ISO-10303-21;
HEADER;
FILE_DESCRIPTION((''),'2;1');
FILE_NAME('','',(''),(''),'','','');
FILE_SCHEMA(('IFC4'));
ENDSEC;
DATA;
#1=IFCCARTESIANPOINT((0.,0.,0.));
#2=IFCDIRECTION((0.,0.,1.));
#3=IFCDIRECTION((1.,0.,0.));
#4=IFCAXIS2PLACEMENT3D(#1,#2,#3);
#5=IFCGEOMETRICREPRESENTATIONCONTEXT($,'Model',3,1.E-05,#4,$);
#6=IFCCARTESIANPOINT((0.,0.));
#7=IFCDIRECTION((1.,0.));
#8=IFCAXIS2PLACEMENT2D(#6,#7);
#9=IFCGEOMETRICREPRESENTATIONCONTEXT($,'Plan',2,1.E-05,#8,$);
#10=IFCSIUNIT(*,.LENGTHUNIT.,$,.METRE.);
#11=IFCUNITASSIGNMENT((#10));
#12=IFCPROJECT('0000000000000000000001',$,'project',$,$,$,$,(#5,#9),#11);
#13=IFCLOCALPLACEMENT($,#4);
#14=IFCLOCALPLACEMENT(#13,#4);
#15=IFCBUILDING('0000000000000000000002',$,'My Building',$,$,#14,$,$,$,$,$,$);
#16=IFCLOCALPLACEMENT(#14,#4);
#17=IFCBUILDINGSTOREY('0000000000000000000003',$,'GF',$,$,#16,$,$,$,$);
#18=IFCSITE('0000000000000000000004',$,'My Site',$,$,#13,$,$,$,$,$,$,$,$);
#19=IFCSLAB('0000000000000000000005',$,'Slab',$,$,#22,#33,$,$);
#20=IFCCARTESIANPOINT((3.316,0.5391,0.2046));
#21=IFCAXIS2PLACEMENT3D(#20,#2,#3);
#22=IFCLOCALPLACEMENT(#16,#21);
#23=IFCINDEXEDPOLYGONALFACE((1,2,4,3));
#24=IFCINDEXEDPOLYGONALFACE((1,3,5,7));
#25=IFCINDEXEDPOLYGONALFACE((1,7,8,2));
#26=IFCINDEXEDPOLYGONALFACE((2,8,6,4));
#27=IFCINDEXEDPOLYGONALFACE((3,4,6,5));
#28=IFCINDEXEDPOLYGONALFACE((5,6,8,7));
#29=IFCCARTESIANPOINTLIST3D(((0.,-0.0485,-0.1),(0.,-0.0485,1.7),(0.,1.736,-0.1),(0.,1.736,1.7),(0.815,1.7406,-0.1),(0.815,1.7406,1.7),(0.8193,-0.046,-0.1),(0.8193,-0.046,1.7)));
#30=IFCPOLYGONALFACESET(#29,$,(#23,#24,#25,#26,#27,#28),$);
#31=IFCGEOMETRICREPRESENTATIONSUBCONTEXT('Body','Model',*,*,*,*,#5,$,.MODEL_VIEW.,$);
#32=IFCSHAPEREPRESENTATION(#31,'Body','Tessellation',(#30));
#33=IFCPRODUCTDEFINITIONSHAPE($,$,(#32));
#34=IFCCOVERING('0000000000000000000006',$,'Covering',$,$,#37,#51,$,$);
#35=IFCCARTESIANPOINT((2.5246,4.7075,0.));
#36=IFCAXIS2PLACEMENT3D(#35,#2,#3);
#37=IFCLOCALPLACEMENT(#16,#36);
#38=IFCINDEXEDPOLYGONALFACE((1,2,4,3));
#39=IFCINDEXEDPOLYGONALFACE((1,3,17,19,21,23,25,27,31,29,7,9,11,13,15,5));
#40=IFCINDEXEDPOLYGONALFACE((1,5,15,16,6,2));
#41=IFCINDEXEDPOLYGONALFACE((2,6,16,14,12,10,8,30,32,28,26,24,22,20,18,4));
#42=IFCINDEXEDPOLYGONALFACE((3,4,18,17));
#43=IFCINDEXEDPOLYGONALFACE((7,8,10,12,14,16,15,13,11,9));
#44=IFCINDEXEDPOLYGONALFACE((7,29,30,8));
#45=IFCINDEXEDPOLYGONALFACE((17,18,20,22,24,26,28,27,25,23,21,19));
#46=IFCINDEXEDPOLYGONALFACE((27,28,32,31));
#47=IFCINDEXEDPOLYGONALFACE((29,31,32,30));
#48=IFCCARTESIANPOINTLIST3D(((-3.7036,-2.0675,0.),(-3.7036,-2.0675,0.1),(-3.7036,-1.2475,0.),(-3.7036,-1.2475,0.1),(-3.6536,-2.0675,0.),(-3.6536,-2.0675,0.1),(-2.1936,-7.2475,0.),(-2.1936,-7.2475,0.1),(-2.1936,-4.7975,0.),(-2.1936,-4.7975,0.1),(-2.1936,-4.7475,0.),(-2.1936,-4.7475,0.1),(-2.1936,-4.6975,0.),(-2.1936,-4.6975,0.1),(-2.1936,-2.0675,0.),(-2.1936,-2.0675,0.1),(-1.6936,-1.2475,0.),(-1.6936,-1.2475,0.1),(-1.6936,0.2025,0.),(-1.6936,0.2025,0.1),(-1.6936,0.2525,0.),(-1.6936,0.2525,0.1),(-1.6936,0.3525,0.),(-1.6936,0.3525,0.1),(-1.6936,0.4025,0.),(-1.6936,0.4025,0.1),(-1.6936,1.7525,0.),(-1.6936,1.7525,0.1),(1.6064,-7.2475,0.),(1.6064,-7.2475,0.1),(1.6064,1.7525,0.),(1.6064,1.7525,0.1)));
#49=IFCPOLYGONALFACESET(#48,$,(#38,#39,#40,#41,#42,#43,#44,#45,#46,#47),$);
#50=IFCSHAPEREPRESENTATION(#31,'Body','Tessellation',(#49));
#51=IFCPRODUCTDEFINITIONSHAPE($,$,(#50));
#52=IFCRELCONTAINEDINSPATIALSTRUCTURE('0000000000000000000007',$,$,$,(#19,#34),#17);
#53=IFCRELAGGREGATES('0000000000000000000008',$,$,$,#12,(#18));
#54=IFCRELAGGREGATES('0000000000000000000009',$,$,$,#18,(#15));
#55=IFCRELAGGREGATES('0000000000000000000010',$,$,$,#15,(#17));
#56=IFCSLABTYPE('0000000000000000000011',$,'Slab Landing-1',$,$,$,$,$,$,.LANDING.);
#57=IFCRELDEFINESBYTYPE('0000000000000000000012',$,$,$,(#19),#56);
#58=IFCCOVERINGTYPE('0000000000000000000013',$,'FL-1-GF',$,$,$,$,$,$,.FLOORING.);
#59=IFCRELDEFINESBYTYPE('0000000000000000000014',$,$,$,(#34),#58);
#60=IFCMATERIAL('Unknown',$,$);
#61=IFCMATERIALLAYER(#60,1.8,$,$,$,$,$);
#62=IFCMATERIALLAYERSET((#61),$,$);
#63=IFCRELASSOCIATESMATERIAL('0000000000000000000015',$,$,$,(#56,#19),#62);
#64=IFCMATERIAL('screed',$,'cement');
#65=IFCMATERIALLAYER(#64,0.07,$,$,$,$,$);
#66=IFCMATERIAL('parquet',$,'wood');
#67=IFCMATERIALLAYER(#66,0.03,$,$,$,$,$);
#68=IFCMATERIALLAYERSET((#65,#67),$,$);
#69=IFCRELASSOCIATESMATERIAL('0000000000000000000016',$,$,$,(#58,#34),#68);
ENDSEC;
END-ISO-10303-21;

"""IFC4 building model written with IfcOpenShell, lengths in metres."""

from ifc_helpers import new_model, si_unit, frame, origin_with_axes, origin_2d_with_axis, place, context, subcontext, project, spatial, line, indexed_curve, outline, extrude, material, layer, layer_set, layer_usage, type_object, element, save


model = new_model("IFC4")

# Units and contexts
model_context = context("Model", 3, precision=1e-05, world=origin_with_axes())
plan_context = context("Plan", 2, precision=1e-05, world=origin_2d_with_axis())
body_context_1 = subcontext(model_context, "Body", "Model", "MODEL_VIEW")
ifc_project = project(units=[si_unit("LENGTHUNIT", "METRE")], contexts=[model_context, plan_context])

# Site, building, storey
site_placement = place(None, origin_with_axes())
site = spatial("IfcSite", under=ifc_project, at=site_placement, Name="My Site")
building_placement = place(site_placement, origin_with_axes())
building = spatial("IfcBuilding", under=site, at=building_placement, Name="My Building")
storey_placement = place(building_placement, origin_with_axes())
storey = spatial("IfcBuildingStorey", under=building, at=storey_placement, Name="GF")

# Slab
ifc_material_1 = material(Name="Unknown")
ifc_layer_1 = layer(ifc_material_1, 1.8)
ifc_layer_set_1 = layer_set([ifc_layer_1])
ifc_layer_usage_1 = layer_usage(ifc_layer_set_1, "AXIS3", "POSITIVE", -0.1)
slab_type_1 = type_object("IfcSlabType", Name="Slab Landing-1", PredefinedType="LANDING", material=ifc_layer_set_1)
slab_1_placement = place(storey_placement, frame((3.316, 0.5391, 0.2046), z_axis=(0.0, 0.0, 1.0), x_axis=(1.0, 0.0, 0.0)))
element("IfcSlab", 1, at=slab_1_placement, inside=storey, type_object=slab_type_1, material=ifc_layer_usage_1, Name="Slab", context=body_context_1, shape_type="SweptSolid", body=[
    extrude(outline(indexed_curve([(0.0, -0.0485), (0.0, 1.736), (0.815, 1.7406), (0.8193, -0.046), (0.0, -0.0485)])), frame((0.0, 0.0, -0.1), z_axis=(0.0, 0.0, 1.0), x_axis=(1.0, 0.0, 0.0)), (0.0, 0.0, 1.0), 1.8),
])

# Covering
ifc_material_2 = material(Name="screed", Category="cement")
ifc_layer_2 = layer(ifc_material_2, 0.07)
ifc_material_3 = material(Name="parquet", Category="wood")
ifc_layer_3 = layer(ifc_material_3, 0.03)
ifc_layer_set_2 = layer_set([ifc_layer_2, ifc_layer_3])
ifc_layer_usage_2 = layer_usage(ifc_layer_set_2, "AXIS3", "POSITIVE", 0.0)
covering_type = type_object("IfcCoveringType", Name="FL-1-GF", PredefinedType="FLOORING", material=ifc_layer_set_2)
covering_placement = place(storey_placement, frame((2.5246, 4.7075, 0.0), z_axis=(0.0, 0.0, 1.0), x_axis=(1.0, 0.0, 0.0)))
element("IfcCovering", 2, at=covering_placement, inside=storey, type_object=covering_type, material=ifc_layer_usage_2, Name="Covering", context=body_context_1, shape_type="SweptSolid", body=[
    extrude(outline(indexed_curve([(-2.1936, -2.0675), (-3.6536, -2.0675), (-3.7036, -2.0675), (-3.7036, -1.2475), (-1.6936, -1.2475), (-1.6936, 0.2025), (-1.6936, 0.2525), (-1.6936, 0.3525), (-1.6936, 0.4025), (-1.6936, 1.7525), (1.6064, 1.7525), (1.6064, -7.2475), (-2.1936, -7.2475), (-2.1936, -7.2475), (-2.1936, -4.7975), (-2.1936, -4.7475), (-2.1936, -4.7475), (-2.1936, -4.6975)], segments=[line(1, 2, 3, 4, 5, 6, 7, 8, 9, 10, 11, 12, 13, 14, 15, 16, 17, 18, 1)])), origin_with_axes(), (0.0, 0.0, 1.0), 0.1),
])

save(model, "model.ifc")
